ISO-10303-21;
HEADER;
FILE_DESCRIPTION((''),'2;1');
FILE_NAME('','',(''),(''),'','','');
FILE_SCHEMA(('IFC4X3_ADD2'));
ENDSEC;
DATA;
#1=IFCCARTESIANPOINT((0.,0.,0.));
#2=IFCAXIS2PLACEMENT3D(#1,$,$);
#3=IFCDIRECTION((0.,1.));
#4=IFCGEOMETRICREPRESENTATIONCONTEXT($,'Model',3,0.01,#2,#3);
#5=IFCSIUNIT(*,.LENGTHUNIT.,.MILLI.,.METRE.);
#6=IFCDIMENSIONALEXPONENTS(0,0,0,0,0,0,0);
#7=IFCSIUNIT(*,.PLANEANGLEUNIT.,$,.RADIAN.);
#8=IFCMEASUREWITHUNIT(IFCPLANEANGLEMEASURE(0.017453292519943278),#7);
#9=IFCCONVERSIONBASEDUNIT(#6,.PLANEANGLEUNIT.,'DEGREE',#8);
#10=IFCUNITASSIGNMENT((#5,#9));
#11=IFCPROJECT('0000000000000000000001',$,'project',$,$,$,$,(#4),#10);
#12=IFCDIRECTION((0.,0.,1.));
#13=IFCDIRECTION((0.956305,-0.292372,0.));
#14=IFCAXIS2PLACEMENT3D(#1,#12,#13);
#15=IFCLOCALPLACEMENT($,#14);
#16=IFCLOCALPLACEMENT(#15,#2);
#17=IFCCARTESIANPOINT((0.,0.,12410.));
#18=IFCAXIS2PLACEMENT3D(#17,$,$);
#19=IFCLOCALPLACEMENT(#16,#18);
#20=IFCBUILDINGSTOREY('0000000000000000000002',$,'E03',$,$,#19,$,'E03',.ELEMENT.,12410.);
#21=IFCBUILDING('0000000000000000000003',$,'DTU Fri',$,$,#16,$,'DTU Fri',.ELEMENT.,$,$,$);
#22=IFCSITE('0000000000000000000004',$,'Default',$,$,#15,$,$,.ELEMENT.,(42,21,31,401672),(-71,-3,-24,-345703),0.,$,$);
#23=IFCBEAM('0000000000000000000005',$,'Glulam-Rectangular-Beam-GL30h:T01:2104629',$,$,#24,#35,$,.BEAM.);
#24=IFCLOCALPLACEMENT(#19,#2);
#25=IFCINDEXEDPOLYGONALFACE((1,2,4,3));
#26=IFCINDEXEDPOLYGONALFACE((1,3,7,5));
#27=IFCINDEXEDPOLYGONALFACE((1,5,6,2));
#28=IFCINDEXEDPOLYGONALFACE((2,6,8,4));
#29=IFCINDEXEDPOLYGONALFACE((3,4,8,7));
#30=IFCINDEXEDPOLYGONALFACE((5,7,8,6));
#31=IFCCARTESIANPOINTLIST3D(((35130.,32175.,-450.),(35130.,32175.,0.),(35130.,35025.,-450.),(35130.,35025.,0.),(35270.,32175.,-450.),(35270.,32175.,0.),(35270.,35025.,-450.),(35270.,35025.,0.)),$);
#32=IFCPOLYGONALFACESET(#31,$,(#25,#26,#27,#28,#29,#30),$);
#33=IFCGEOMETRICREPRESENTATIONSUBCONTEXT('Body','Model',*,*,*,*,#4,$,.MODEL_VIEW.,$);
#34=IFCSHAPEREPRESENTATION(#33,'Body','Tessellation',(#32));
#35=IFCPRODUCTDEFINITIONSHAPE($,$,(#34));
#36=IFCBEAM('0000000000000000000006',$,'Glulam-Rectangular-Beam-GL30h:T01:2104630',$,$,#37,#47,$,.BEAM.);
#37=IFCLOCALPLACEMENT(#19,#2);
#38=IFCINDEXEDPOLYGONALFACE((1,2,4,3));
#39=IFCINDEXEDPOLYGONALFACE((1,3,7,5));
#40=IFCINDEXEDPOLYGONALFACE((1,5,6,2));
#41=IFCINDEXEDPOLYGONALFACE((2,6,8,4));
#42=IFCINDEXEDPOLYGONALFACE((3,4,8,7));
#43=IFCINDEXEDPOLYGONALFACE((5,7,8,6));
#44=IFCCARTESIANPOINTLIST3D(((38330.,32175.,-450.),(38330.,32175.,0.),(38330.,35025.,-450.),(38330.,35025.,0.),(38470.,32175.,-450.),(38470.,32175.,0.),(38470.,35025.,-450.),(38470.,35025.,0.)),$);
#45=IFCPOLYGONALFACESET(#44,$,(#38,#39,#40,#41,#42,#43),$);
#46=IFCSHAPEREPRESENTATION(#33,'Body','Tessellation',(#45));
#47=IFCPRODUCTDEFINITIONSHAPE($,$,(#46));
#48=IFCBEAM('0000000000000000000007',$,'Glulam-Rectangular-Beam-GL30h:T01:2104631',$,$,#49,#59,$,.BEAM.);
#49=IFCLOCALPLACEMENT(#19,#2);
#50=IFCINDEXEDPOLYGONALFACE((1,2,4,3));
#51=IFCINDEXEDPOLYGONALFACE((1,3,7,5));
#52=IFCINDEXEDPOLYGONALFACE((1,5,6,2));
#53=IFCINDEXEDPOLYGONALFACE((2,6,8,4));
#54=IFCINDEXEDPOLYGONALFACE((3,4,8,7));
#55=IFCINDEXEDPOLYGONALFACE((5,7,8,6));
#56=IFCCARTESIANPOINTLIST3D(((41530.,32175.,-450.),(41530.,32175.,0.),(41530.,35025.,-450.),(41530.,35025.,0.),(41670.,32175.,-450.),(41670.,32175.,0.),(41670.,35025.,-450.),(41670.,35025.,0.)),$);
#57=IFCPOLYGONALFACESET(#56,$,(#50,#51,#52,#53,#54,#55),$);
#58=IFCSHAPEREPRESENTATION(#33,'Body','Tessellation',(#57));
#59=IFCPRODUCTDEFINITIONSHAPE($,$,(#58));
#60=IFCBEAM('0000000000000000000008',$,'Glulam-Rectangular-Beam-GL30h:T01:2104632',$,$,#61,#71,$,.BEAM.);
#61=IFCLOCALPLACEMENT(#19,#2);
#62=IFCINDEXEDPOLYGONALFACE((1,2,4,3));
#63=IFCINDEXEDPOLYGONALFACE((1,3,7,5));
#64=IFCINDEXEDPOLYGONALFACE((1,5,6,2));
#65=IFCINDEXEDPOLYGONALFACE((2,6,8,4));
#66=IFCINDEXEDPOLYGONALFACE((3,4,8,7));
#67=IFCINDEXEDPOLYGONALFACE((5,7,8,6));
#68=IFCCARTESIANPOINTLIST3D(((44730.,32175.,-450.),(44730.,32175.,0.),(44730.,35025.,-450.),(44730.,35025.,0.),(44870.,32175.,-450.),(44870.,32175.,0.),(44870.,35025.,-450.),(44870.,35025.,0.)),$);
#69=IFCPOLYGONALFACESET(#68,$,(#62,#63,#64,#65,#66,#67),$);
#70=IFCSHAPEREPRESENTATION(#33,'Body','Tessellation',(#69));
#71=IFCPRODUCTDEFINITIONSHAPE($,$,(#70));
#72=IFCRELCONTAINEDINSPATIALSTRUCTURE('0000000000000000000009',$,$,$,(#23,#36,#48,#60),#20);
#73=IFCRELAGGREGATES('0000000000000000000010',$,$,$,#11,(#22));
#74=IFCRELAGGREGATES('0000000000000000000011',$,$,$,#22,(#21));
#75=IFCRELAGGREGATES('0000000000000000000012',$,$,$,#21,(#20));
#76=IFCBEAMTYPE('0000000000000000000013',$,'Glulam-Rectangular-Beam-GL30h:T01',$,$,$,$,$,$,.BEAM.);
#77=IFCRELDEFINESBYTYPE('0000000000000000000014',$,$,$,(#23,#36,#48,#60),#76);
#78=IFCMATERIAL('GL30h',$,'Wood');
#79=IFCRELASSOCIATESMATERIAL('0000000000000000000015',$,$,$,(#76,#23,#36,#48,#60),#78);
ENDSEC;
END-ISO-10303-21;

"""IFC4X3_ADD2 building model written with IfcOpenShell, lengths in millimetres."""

from ifc_helpers import new_model, entity, si_unit, converted_unit, direction, frame, origin, origin_2d_with_axis, place, context, subcontext, project, spatial, rectangle, extrude, source, transform, mapped, material, material_profile, profile_set, profile_usage, type_object, type_shapes, element, save


model = new_model("IFC4X3_ADD2")

# Units and contexts
model_context = context("Model", 3, precision=0.01, world=origin(), true_north=direction((0.0, 1.0)))
body_context = subcontext(model_context, "Body", "Model", "MODEL_VIEW")
ifc_project = project(units=[si_unit("LENGTHUNIT", "METRE", prefix="MILLI"), converted_unit("PLANEANGLEUNIT", "DEGREE", entity("IfcPlaneAngleMeasure", 0.017453292519943278), si_unit("PLANEANGLEUNIT", "RADIAN"), dimensions=[0, 0, 0, 0, 0, 0, 0])], contexts=[model_context])

# Site, building, storey
site_placement = place(None, frame((0.0, 0.0, 0.0), z_axis=(0.0, 0.0, 1.0), x_axis=(0.956305, -0.292372, 0.0)))
site = spatial("IfcSite", under=ifc_project, at=site_placement, Name="Default", CompositionType="ELEMENT", RefLatitude=(42, 21, 31, 401672), RefLongitude=(-71, -3, -24, -345703), RefElevation=0.0)
building_placement = place(site_placement, origin())
building = spatial("IfcBuilding", under=site, at=building_placement, Name="DTU Fri", LongName="DTU Fri", CompositionType="ELEMENT")
storey_placement = place(building_placement, frame((0.0, 0.0, 12410.0)))
storey = spatial("IfcBuildingStorey", under=building, at=storey_placement, Name="E03", LongName="E03", CompositionType="ELEMENT", Elevation=12410.0)

# Shared definitions
ifc_material = material(Name="GL30h", Category="Wood")

# Beams
ifc_material_profile_1 = material_profile(ifc_material, rectangle(XDim=450.0, YDim=140.0, at=origin_2d_with_axis()), Name="T01")
ifc_profile_set_1 = profile_set([ifc_material_profile_1], Name="T01")
ifc_profile_usage_1 = profile_usage(ifc_profile_set_1, cardinal=8)
beam_type_1 = type_object("IfcBeamType", Name="Glulam-Rectangular-Beam-GL30h:T01", PredefinedType="BEAM", material=ifc_profile_set_1)
shared_shape_1 = source(origin(), body_context, "Body", "SweptSolid", [
    extrude(rectangle(XDim=450.0, YDim=140.0, at=origin_2d_with_axis()), frame((-1425.0, 0.0, 0.0), z_axis=(1.0, 0.0, 0.0), x_axis=(0.0, 0.0, -1.0)), (0.0, 0.0, 1.0), 2850.0),
])
type_shapes(beam_type_1, [shared_shape_1])
for number, where, z_axis, x_axis, name in (
    (1, (35200.0, 33600.0, -225.0), (0.0, 0.0, 1.0), (0.0, 1.0, 0.0), "Glulam-Rectangular-Beam-GL30h:T01:2104629"),
    (2, (38400.0, 33600.0, -225.0), (0.0, 0.0, 1.0), (0.0, 1.0, 0.0), "Glulam-Rectangular-Beam-GL30h:T01:2104630"),
    (3, (41600.0, 33600.0, -225.0), (0.0, 0.0, 1.0), (0.0, 1.0, 0.0), "Glulam-Rectangular-Beam-GL30h:T01:2104631"),
    (4, (44800.0, 33600.0, -225.0), (0.0, 0.0, 1.0), (0.0, 1.0, 0.0), "Glulam-Rectangular-Beam-GL30h:T01:2104632"),
):
    element("IfcBeam", number, at=place(storey_placement, frame(where, z_axis=z_axis, x_axis=x_axis)), inside=storey, type_object=beam_type_1, material=ifc_profile_usage_1, Name=name, PredefinedType="BEAM", context=body_context, shape_type="MappedRepresentation", body=[
        mapped(shared_shape_1, transform((0.0, 0.0, 0.0), scale=1.0)),
    ])

save(model, "model.ifc")
